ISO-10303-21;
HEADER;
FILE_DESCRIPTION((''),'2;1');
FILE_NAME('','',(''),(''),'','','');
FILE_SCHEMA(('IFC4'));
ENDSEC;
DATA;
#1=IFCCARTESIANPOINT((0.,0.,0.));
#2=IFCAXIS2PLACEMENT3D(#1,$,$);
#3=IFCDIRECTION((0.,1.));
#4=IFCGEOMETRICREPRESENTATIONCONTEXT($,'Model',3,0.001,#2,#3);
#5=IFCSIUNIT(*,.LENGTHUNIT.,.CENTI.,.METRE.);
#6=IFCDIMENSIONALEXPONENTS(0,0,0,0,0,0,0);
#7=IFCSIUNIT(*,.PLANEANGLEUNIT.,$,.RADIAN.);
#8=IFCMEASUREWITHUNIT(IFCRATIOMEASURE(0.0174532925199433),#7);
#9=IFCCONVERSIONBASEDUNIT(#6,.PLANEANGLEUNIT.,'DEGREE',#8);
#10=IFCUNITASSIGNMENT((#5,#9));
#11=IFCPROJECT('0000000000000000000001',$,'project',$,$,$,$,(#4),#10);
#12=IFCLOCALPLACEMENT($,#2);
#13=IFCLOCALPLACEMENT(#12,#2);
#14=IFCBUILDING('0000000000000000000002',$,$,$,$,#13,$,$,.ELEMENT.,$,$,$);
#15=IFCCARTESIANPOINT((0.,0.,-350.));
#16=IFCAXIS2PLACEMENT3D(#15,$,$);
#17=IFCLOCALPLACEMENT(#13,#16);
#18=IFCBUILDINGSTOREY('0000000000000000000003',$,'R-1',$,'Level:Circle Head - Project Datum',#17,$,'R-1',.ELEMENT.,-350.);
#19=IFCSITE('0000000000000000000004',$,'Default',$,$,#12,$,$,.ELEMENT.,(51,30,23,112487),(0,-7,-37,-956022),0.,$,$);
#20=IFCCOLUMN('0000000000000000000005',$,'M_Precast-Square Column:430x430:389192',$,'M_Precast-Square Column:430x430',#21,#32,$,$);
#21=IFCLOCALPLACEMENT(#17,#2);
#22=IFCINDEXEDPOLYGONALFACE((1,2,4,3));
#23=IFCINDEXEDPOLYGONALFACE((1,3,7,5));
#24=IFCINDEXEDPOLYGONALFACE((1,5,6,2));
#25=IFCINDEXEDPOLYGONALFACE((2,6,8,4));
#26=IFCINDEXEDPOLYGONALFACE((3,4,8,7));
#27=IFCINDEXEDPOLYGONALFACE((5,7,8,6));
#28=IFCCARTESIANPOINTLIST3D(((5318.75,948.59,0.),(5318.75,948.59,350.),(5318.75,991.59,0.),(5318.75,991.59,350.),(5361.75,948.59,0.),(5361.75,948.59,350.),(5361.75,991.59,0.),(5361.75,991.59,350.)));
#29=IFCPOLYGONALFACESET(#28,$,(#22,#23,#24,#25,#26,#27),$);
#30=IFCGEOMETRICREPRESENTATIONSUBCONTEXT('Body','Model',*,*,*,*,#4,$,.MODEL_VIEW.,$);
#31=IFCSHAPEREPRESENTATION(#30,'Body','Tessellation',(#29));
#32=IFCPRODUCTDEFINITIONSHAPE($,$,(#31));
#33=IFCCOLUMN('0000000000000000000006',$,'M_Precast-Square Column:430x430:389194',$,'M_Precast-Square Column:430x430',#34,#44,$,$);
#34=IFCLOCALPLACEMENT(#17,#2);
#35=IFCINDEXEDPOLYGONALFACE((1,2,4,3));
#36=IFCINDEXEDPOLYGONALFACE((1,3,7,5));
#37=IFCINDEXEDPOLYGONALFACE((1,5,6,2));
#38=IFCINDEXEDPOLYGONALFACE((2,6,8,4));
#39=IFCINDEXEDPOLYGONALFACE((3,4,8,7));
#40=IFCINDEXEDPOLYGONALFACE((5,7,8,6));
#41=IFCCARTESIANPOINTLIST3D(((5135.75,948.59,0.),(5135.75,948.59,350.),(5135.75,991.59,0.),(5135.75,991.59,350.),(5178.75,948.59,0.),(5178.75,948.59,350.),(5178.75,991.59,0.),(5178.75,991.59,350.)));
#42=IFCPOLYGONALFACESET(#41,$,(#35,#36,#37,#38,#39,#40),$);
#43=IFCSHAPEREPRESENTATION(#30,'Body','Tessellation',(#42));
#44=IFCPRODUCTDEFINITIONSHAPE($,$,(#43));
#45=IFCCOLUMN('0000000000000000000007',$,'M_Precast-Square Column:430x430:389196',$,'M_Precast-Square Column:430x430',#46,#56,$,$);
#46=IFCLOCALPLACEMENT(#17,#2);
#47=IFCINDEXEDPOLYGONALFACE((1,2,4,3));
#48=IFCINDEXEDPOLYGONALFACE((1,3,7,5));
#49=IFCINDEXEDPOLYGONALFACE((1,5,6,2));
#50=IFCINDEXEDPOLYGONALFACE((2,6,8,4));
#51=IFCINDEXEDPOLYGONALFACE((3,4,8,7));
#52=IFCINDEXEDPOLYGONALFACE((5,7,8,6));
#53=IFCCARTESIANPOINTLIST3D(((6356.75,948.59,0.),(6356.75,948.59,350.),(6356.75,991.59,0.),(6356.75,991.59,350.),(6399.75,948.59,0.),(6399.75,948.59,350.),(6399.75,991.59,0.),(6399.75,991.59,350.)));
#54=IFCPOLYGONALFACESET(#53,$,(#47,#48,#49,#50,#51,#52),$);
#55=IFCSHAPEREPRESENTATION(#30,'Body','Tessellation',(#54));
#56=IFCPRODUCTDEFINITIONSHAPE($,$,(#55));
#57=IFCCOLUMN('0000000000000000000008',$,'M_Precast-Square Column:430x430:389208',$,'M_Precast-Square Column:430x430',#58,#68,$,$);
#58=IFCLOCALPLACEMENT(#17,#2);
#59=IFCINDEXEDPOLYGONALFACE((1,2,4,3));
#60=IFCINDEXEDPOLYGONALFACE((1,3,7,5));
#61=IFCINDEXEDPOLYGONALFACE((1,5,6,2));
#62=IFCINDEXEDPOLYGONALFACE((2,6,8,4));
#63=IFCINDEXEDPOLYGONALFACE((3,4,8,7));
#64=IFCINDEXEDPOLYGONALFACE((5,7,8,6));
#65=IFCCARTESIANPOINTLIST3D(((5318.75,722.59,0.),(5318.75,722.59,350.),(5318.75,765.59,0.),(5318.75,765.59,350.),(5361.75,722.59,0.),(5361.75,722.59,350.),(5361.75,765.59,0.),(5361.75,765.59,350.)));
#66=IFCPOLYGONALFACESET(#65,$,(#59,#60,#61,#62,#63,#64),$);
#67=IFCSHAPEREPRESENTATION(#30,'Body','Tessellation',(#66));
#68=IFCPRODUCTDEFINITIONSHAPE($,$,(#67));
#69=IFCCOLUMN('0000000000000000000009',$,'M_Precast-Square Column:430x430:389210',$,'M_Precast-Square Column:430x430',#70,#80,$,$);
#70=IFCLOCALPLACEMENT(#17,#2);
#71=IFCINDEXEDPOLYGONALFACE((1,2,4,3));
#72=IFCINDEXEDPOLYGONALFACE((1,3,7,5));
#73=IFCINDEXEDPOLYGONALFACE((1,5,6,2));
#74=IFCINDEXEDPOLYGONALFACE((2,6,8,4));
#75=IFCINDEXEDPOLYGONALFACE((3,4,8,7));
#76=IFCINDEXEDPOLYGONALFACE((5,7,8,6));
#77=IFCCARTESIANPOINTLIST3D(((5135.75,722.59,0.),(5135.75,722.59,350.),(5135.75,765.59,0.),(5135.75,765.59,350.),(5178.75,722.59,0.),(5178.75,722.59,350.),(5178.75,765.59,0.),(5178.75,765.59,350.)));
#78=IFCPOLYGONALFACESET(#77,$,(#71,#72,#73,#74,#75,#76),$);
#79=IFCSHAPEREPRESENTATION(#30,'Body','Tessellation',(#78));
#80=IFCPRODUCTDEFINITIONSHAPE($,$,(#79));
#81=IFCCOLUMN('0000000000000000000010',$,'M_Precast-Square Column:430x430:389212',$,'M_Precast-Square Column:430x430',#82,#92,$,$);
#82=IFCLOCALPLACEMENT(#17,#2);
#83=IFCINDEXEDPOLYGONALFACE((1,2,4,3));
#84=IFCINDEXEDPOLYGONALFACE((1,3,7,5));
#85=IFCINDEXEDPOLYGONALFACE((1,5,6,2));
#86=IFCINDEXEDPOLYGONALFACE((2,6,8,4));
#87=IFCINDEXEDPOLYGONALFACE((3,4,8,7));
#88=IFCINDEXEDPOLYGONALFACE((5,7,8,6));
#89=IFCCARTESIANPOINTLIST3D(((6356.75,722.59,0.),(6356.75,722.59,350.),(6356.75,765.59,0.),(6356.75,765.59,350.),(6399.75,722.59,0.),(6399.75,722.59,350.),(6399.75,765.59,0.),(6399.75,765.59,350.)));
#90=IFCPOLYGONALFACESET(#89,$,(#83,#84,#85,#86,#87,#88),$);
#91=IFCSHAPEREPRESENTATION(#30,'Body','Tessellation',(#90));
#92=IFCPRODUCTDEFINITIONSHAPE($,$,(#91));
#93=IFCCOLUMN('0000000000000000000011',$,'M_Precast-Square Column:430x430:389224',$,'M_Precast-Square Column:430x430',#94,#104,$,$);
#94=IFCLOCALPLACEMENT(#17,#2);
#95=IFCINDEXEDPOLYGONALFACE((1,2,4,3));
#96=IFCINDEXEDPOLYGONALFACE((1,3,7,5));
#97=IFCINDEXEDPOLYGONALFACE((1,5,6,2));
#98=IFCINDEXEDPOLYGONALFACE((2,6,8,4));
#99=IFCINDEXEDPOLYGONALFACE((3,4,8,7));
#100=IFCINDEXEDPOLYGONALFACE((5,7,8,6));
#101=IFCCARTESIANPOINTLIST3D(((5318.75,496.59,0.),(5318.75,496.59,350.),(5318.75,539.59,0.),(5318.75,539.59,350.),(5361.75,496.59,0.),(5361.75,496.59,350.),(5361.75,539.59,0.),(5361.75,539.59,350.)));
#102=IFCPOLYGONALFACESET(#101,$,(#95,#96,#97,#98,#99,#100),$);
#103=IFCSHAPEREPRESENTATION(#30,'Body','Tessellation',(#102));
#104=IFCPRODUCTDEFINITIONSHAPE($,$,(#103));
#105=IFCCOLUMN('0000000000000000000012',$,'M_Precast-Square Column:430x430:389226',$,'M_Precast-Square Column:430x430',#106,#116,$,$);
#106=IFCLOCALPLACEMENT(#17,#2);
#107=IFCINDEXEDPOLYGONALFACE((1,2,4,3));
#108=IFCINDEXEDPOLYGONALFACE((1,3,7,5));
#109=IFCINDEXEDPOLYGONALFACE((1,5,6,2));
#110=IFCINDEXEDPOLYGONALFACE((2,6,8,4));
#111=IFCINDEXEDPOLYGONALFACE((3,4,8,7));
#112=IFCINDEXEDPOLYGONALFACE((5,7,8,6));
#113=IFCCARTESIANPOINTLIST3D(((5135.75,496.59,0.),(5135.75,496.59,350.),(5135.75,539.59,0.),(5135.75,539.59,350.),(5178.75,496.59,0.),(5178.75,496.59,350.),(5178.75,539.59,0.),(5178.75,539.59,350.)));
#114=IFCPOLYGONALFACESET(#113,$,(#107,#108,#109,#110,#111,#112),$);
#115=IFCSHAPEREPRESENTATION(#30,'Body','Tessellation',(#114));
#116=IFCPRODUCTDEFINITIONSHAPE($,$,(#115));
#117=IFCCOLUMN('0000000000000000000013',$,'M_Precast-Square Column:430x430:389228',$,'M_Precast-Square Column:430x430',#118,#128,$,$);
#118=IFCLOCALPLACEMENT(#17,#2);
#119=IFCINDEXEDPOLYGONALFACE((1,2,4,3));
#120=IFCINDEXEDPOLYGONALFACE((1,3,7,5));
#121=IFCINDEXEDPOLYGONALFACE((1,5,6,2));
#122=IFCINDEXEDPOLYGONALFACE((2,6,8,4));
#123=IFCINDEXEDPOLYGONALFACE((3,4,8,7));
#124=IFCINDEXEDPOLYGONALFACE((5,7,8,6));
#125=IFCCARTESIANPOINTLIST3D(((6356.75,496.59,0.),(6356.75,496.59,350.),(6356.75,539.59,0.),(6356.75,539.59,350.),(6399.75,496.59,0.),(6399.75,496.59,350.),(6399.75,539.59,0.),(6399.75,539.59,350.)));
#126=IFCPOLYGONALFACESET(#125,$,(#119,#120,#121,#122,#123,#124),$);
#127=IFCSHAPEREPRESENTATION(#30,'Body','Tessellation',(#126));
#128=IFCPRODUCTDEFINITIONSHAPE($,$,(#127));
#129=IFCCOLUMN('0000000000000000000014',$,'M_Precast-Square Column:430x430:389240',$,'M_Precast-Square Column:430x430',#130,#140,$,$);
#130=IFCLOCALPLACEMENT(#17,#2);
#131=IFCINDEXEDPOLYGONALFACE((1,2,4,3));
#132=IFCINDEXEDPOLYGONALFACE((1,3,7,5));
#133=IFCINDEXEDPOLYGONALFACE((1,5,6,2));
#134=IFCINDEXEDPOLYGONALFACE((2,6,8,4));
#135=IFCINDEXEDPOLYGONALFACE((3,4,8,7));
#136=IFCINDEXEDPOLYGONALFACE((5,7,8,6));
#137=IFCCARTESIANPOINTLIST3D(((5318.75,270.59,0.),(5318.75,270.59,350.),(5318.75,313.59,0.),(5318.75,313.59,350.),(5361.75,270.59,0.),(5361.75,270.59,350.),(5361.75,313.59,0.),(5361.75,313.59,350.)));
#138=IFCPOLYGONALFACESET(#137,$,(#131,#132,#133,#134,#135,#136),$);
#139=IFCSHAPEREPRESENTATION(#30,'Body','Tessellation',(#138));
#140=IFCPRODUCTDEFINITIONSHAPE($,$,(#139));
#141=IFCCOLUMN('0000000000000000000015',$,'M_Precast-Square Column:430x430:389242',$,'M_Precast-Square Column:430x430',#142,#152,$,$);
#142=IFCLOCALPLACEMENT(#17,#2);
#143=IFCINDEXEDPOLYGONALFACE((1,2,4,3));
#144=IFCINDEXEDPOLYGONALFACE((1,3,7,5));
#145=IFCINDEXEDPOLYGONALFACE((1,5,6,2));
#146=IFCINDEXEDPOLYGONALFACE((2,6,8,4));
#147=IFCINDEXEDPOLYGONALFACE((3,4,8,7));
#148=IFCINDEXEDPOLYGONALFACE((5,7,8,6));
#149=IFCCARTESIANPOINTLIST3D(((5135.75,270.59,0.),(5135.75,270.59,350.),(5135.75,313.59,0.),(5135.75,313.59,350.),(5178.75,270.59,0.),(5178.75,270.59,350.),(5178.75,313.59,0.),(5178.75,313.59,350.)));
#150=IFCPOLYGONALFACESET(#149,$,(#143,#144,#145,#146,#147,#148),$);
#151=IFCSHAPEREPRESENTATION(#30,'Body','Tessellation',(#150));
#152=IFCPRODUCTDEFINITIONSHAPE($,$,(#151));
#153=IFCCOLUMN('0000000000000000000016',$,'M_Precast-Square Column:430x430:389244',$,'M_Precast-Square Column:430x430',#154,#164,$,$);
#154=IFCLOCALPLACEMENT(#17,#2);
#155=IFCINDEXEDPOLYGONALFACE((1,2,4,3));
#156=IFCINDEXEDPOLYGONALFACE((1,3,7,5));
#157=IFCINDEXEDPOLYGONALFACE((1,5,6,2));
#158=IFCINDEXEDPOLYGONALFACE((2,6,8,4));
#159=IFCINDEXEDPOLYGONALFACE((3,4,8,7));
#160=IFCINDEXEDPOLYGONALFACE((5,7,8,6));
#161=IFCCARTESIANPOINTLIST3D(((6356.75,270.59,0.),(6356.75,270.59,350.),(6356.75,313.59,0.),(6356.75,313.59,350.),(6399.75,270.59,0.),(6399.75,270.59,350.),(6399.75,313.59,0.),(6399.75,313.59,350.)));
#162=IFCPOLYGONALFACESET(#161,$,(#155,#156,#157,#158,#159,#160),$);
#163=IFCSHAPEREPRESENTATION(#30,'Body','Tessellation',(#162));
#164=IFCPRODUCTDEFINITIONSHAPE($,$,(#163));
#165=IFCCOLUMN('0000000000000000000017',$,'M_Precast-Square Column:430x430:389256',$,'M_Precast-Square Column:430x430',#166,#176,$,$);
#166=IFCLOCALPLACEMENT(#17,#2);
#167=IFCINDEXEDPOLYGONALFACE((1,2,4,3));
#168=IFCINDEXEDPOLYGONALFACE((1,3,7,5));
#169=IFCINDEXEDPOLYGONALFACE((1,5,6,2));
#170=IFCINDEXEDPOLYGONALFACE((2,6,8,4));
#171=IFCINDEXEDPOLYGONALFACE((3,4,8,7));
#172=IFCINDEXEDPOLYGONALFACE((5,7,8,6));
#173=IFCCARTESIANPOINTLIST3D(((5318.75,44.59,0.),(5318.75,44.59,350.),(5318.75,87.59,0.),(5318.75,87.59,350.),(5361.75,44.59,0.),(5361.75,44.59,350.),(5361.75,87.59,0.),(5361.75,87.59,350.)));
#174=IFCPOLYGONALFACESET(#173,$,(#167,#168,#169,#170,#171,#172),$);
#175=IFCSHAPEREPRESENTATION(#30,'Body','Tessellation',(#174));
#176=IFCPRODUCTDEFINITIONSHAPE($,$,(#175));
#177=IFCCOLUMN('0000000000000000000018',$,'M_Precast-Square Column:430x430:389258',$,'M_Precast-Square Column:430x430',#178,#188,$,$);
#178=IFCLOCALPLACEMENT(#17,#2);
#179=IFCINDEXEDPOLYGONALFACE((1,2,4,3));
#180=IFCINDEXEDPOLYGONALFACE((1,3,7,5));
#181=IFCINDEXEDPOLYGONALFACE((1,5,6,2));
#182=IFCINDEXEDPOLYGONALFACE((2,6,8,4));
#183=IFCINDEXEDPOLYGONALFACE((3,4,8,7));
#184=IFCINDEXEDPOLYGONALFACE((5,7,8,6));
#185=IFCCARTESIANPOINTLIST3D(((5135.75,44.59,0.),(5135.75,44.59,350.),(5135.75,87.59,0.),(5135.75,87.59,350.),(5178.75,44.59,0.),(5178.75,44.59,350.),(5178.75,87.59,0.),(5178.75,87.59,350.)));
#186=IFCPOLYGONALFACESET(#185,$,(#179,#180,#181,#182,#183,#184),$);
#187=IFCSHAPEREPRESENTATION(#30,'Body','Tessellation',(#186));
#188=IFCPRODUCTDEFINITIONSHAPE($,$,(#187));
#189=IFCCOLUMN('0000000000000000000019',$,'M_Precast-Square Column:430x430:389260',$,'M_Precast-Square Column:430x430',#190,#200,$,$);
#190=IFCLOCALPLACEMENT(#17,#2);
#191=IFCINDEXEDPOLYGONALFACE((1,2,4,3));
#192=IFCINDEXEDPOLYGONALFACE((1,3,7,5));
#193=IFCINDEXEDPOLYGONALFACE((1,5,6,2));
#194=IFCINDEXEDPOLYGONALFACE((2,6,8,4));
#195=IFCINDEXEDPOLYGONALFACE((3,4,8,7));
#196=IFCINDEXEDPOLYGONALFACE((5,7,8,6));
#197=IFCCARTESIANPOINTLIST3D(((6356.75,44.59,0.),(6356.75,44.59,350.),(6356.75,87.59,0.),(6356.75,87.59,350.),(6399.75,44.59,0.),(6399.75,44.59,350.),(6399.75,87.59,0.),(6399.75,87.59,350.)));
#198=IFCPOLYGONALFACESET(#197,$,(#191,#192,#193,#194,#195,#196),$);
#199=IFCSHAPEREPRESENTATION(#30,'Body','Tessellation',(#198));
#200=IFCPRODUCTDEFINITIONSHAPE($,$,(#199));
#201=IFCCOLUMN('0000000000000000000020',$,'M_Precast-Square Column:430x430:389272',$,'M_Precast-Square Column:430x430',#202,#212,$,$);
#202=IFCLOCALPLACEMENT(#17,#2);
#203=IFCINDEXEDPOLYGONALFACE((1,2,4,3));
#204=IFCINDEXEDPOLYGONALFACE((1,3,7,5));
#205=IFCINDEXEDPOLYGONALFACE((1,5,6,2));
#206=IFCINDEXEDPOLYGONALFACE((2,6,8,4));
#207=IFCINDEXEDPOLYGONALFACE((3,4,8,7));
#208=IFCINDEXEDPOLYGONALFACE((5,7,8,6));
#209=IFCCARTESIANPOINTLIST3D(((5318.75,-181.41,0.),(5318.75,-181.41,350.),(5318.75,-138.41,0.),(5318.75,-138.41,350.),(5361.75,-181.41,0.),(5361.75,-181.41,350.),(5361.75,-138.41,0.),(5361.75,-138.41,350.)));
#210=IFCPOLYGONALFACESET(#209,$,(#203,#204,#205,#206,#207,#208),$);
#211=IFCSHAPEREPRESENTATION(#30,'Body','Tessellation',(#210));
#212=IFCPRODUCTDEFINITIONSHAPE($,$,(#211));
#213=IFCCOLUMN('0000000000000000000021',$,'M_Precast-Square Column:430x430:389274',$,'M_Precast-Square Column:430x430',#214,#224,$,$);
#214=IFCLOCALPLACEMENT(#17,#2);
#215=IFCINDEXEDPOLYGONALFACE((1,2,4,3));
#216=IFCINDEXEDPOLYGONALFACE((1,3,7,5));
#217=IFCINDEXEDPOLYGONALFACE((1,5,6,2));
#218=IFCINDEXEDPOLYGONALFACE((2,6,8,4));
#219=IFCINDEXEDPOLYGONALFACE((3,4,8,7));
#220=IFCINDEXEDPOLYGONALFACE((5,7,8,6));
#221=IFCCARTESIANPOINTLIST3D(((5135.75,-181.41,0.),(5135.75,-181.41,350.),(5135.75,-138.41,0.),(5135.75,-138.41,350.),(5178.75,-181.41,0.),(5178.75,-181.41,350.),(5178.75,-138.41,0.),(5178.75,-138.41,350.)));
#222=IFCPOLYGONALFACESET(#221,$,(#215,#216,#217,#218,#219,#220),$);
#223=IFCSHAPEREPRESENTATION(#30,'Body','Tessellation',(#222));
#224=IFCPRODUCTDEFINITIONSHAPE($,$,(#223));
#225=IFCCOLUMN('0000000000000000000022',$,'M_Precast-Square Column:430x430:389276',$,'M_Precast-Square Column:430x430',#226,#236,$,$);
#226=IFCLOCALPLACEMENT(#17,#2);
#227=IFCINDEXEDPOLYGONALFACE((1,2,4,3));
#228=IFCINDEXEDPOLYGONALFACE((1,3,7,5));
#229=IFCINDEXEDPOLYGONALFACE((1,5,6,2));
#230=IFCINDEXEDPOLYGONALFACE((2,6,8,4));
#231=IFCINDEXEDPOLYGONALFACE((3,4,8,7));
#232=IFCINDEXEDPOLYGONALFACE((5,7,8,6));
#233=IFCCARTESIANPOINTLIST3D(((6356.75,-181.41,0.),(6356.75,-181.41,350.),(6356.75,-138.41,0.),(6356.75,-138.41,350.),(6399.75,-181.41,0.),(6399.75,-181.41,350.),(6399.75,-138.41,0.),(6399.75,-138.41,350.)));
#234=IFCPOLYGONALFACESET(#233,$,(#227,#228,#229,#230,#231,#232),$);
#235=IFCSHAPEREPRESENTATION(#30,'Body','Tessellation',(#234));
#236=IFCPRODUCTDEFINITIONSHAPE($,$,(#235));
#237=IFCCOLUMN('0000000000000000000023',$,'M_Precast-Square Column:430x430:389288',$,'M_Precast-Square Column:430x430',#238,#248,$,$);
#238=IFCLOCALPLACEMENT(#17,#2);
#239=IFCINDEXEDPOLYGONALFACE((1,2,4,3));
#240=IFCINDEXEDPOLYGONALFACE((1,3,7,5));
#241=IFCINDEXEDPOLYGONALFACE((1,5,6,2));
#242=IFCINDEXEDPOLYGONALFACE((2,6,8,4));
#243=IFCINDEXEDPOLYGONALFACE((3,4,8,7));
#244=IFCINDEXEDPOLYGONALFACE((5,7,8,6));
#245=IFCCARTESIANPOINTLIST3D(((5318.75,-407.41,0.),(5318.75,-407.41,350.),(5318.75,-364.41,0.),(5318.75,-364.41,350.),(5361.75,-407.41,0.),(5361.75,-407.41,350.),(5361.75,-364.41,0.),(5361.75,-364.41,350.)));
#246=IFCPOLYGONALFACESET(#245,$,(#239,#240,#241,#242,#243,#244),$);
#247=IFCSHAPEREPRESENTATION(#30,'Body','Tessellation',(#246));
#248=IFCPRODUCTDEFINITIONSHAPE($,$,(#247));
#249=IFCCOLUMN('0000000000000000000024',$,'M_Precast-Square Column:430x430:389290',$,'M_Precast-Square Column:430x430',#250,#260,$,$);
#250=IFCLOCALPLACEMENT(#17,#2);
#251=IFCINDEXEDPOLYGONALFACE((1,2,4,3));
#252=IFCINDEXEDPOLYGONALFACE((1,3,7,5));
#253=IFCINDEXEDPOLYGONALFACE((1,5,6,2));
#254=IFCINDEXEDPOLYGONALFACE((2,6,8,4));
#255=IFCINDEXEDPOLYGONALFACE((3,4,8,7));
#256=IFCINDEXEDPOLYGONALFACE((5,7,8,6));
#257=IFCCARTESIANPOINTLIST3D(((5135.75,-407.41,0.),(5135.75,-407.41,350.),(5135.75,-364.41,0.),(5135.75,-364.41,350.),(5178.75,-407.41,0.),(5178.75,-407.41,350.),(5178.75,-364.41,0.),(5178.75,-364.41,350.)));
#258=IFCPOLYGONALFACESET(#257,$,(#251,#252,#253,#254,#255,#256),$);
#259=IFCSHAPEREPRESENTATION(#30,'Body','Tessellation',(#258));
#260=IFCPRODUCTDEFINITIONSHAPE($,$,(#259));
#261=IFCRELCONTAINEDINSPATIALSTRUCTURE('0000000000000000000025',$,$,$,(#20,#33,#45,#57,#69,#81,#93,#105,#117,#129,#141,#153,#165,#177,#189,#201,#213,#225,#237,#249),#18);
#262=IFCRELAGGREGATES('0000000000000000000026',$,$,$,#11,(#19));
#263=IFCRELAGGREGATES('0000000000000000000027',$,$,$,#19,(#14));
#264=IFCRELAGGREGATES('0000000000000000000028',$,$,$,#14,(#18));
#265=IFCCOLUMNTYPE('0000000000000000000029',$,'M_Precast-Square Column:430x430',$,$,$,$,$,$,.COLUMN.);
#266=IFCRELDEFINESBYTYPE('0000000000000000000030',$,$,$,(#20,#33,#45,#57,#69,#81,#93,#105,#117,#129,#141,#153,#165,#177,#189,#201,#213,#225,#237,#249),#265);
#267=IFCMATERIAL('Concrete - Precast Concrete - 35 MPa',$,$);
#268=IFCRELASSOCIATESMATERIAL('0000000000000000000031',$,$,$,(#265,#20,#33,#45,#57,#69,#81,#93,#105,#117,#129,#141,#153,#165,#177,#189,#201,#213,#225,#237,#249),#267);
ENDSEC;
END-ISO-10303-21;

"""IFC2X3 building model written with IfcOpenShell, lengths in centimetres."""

from ifc_helpers import new_model, entity, si_unit, converted_unit, direction, frame, origin, origin_2d_with_axis, place, context, subcontext, project, spatial, rectangle, extrude, source, transform, mapped, material, type_object, type_shapes, element, save


model = new_model("IFC2X3")

# Units and contexts
model_context = context("Model", 3, precision=0.001, world=origin(), true_north=direction((0.0, 1.0)))
body_context = subcontext(model_context, "Body", "Model", "MODEL_VIEW")
ifc_project = project(units=[si_unit("LENGTHUNIT", "METRE", prefix="CENTI"), converted_unit("PLANEANGLEUNIT", "DEGREE", entity("IfcRatioMeasure", 0.0174532925199433), si_unit("PLANEANGLEUNIT", "RADIAN"), dimensions=[0, 0, 0, 0, 0, 0, 0])], contexts=[model_context])

# Site, building, storey
site_placement = place(None, origin())
site = spatial("IfcSite", under=ifc_project, at=site_placement, Name="Default", CompositionType="ELEMENT", RefLatitude=(51, 30, 23, 112487), RefLongitude=(0, -7, -37, -956022), RefElevation=0.0)
building_placement = place(site_placement, origin())
building = spatial("IfcBuilding", under=site, at=building_placement, CompositionType="ELEMENT")
storey_placement = place(building_placement, frame((0.0, 0.0, -350.0)))
storey = spatial("IfcBuildingStorey", under=building, at=storey_placement, Name="R-1", ObjectType="Level:Circle Head - Project Datum", LongName="R-1", CompositionType="ELEMENT", Elevation=-350.0)

# Columns
ifc_material = material(Name="Concrete - Precast Concrete - 35 MPa")
column_type = type_object("IfcColumnType", Name="M_Precast-Square Column:430x430", PredefinedType="COLUMN", material=ifc_material)
shared_shape = source(origin(), body_context, "Body", "SweptSolid", [
    extrude(rectangle(XDim=43.0, YDim=43.0, at=origin_2d_with_axis()), frame((0.0, 0.0, -350.0), z_axis=(0.0, 0.0, 1.0), x_axis=(0.0, -1.0, 0.0)), (0.0, 0.0, 1.0), 350.0),
])
type_shapes(column_type, [shared_shape])
for number, where, name in (
    (1, (5340.25, 970.09, 350.0), "M_Precast-Square Column:430x430:389192"),
    (2, (5157.25, 970.09, 350.0), "M_Precast-Square Column:430x430:389194"),
    (3, (6378.25, 970.09, 350.0), "M_Precast-Square Column:430x430:389196"),
    (4, (5340.25, 744.09, 350.0), "M_Precast-Square Column:430x430:389208"),
    (5, (5157.25, 744.09, 350.0), "M_Precast-Square Column:430x430:389210"),
    (6, (6378.25, 744.09, 350.0), "M_Precast-Square Column:430x430:389212"),
    (7, (5340.25, 518.09, 350.0), "M_Precast-Square Column:430x430:389224"),
    (8, (5157.25, 518.09, 350.0), "M_Precast-Square Column:430x430:389226"),
    (9, (6378.25, 518.09, 350.0), "M_Precast-Square Column:430x430:389228"),
    (10, (5340.25, 292.09, 350.0), "M_Precast-Square Column:430x430:389240"),
    (11, (5157.25, 292.09, 350.0), "M_Precast-Square Column:430x430:389242"),
    (12, (6378.25, 292.09, 350.0), "M_Precast-Square Column:430x430:389244"),
    (13, (5340.25, 66.09, 350.0), "M_Precast-Square Column:430x430:389256"),
    (14, (5157.25, 66.09, 350.0), "M_Precast-Square Column:430x430:389258"),
    (15, (6378.25, 66.09, 350.0), "M_Precast-Square Column:430x430:389260"),
    (16, (5340.25, -159.91, 350.0), "M_Precast-Square Column:430x430:389272"),
    (17, (5157.25, -159.91, 350.0), "M_Precast-Square Column:430x430:389274"),
    (18, (6378.25, -159.91, 350.0), "M_Precast-Square Column:430x430:389276"),
    (19, (5340.25, -385.91, 350.0), "M_Precast-Square Column:430x430:389288"),
    (20, (5157.25, -385.91, 350.0), "M_Precast-Square Column:430x430:389290"),
):
    element("IfcColumn", number, at=place(storey_placement, frame(where)), inside=storey, type_object=column_type, material=ifc_material, Name=name, ObjectType="M_Precast-Square Column:430x430", context=body_context, shape_type="MappedRepresentation", body=[
        mapped(shared_shape, transform((0.0, 0.0, 0.0), scale=1.0)),
    ])

save(model, "model.ifc")
